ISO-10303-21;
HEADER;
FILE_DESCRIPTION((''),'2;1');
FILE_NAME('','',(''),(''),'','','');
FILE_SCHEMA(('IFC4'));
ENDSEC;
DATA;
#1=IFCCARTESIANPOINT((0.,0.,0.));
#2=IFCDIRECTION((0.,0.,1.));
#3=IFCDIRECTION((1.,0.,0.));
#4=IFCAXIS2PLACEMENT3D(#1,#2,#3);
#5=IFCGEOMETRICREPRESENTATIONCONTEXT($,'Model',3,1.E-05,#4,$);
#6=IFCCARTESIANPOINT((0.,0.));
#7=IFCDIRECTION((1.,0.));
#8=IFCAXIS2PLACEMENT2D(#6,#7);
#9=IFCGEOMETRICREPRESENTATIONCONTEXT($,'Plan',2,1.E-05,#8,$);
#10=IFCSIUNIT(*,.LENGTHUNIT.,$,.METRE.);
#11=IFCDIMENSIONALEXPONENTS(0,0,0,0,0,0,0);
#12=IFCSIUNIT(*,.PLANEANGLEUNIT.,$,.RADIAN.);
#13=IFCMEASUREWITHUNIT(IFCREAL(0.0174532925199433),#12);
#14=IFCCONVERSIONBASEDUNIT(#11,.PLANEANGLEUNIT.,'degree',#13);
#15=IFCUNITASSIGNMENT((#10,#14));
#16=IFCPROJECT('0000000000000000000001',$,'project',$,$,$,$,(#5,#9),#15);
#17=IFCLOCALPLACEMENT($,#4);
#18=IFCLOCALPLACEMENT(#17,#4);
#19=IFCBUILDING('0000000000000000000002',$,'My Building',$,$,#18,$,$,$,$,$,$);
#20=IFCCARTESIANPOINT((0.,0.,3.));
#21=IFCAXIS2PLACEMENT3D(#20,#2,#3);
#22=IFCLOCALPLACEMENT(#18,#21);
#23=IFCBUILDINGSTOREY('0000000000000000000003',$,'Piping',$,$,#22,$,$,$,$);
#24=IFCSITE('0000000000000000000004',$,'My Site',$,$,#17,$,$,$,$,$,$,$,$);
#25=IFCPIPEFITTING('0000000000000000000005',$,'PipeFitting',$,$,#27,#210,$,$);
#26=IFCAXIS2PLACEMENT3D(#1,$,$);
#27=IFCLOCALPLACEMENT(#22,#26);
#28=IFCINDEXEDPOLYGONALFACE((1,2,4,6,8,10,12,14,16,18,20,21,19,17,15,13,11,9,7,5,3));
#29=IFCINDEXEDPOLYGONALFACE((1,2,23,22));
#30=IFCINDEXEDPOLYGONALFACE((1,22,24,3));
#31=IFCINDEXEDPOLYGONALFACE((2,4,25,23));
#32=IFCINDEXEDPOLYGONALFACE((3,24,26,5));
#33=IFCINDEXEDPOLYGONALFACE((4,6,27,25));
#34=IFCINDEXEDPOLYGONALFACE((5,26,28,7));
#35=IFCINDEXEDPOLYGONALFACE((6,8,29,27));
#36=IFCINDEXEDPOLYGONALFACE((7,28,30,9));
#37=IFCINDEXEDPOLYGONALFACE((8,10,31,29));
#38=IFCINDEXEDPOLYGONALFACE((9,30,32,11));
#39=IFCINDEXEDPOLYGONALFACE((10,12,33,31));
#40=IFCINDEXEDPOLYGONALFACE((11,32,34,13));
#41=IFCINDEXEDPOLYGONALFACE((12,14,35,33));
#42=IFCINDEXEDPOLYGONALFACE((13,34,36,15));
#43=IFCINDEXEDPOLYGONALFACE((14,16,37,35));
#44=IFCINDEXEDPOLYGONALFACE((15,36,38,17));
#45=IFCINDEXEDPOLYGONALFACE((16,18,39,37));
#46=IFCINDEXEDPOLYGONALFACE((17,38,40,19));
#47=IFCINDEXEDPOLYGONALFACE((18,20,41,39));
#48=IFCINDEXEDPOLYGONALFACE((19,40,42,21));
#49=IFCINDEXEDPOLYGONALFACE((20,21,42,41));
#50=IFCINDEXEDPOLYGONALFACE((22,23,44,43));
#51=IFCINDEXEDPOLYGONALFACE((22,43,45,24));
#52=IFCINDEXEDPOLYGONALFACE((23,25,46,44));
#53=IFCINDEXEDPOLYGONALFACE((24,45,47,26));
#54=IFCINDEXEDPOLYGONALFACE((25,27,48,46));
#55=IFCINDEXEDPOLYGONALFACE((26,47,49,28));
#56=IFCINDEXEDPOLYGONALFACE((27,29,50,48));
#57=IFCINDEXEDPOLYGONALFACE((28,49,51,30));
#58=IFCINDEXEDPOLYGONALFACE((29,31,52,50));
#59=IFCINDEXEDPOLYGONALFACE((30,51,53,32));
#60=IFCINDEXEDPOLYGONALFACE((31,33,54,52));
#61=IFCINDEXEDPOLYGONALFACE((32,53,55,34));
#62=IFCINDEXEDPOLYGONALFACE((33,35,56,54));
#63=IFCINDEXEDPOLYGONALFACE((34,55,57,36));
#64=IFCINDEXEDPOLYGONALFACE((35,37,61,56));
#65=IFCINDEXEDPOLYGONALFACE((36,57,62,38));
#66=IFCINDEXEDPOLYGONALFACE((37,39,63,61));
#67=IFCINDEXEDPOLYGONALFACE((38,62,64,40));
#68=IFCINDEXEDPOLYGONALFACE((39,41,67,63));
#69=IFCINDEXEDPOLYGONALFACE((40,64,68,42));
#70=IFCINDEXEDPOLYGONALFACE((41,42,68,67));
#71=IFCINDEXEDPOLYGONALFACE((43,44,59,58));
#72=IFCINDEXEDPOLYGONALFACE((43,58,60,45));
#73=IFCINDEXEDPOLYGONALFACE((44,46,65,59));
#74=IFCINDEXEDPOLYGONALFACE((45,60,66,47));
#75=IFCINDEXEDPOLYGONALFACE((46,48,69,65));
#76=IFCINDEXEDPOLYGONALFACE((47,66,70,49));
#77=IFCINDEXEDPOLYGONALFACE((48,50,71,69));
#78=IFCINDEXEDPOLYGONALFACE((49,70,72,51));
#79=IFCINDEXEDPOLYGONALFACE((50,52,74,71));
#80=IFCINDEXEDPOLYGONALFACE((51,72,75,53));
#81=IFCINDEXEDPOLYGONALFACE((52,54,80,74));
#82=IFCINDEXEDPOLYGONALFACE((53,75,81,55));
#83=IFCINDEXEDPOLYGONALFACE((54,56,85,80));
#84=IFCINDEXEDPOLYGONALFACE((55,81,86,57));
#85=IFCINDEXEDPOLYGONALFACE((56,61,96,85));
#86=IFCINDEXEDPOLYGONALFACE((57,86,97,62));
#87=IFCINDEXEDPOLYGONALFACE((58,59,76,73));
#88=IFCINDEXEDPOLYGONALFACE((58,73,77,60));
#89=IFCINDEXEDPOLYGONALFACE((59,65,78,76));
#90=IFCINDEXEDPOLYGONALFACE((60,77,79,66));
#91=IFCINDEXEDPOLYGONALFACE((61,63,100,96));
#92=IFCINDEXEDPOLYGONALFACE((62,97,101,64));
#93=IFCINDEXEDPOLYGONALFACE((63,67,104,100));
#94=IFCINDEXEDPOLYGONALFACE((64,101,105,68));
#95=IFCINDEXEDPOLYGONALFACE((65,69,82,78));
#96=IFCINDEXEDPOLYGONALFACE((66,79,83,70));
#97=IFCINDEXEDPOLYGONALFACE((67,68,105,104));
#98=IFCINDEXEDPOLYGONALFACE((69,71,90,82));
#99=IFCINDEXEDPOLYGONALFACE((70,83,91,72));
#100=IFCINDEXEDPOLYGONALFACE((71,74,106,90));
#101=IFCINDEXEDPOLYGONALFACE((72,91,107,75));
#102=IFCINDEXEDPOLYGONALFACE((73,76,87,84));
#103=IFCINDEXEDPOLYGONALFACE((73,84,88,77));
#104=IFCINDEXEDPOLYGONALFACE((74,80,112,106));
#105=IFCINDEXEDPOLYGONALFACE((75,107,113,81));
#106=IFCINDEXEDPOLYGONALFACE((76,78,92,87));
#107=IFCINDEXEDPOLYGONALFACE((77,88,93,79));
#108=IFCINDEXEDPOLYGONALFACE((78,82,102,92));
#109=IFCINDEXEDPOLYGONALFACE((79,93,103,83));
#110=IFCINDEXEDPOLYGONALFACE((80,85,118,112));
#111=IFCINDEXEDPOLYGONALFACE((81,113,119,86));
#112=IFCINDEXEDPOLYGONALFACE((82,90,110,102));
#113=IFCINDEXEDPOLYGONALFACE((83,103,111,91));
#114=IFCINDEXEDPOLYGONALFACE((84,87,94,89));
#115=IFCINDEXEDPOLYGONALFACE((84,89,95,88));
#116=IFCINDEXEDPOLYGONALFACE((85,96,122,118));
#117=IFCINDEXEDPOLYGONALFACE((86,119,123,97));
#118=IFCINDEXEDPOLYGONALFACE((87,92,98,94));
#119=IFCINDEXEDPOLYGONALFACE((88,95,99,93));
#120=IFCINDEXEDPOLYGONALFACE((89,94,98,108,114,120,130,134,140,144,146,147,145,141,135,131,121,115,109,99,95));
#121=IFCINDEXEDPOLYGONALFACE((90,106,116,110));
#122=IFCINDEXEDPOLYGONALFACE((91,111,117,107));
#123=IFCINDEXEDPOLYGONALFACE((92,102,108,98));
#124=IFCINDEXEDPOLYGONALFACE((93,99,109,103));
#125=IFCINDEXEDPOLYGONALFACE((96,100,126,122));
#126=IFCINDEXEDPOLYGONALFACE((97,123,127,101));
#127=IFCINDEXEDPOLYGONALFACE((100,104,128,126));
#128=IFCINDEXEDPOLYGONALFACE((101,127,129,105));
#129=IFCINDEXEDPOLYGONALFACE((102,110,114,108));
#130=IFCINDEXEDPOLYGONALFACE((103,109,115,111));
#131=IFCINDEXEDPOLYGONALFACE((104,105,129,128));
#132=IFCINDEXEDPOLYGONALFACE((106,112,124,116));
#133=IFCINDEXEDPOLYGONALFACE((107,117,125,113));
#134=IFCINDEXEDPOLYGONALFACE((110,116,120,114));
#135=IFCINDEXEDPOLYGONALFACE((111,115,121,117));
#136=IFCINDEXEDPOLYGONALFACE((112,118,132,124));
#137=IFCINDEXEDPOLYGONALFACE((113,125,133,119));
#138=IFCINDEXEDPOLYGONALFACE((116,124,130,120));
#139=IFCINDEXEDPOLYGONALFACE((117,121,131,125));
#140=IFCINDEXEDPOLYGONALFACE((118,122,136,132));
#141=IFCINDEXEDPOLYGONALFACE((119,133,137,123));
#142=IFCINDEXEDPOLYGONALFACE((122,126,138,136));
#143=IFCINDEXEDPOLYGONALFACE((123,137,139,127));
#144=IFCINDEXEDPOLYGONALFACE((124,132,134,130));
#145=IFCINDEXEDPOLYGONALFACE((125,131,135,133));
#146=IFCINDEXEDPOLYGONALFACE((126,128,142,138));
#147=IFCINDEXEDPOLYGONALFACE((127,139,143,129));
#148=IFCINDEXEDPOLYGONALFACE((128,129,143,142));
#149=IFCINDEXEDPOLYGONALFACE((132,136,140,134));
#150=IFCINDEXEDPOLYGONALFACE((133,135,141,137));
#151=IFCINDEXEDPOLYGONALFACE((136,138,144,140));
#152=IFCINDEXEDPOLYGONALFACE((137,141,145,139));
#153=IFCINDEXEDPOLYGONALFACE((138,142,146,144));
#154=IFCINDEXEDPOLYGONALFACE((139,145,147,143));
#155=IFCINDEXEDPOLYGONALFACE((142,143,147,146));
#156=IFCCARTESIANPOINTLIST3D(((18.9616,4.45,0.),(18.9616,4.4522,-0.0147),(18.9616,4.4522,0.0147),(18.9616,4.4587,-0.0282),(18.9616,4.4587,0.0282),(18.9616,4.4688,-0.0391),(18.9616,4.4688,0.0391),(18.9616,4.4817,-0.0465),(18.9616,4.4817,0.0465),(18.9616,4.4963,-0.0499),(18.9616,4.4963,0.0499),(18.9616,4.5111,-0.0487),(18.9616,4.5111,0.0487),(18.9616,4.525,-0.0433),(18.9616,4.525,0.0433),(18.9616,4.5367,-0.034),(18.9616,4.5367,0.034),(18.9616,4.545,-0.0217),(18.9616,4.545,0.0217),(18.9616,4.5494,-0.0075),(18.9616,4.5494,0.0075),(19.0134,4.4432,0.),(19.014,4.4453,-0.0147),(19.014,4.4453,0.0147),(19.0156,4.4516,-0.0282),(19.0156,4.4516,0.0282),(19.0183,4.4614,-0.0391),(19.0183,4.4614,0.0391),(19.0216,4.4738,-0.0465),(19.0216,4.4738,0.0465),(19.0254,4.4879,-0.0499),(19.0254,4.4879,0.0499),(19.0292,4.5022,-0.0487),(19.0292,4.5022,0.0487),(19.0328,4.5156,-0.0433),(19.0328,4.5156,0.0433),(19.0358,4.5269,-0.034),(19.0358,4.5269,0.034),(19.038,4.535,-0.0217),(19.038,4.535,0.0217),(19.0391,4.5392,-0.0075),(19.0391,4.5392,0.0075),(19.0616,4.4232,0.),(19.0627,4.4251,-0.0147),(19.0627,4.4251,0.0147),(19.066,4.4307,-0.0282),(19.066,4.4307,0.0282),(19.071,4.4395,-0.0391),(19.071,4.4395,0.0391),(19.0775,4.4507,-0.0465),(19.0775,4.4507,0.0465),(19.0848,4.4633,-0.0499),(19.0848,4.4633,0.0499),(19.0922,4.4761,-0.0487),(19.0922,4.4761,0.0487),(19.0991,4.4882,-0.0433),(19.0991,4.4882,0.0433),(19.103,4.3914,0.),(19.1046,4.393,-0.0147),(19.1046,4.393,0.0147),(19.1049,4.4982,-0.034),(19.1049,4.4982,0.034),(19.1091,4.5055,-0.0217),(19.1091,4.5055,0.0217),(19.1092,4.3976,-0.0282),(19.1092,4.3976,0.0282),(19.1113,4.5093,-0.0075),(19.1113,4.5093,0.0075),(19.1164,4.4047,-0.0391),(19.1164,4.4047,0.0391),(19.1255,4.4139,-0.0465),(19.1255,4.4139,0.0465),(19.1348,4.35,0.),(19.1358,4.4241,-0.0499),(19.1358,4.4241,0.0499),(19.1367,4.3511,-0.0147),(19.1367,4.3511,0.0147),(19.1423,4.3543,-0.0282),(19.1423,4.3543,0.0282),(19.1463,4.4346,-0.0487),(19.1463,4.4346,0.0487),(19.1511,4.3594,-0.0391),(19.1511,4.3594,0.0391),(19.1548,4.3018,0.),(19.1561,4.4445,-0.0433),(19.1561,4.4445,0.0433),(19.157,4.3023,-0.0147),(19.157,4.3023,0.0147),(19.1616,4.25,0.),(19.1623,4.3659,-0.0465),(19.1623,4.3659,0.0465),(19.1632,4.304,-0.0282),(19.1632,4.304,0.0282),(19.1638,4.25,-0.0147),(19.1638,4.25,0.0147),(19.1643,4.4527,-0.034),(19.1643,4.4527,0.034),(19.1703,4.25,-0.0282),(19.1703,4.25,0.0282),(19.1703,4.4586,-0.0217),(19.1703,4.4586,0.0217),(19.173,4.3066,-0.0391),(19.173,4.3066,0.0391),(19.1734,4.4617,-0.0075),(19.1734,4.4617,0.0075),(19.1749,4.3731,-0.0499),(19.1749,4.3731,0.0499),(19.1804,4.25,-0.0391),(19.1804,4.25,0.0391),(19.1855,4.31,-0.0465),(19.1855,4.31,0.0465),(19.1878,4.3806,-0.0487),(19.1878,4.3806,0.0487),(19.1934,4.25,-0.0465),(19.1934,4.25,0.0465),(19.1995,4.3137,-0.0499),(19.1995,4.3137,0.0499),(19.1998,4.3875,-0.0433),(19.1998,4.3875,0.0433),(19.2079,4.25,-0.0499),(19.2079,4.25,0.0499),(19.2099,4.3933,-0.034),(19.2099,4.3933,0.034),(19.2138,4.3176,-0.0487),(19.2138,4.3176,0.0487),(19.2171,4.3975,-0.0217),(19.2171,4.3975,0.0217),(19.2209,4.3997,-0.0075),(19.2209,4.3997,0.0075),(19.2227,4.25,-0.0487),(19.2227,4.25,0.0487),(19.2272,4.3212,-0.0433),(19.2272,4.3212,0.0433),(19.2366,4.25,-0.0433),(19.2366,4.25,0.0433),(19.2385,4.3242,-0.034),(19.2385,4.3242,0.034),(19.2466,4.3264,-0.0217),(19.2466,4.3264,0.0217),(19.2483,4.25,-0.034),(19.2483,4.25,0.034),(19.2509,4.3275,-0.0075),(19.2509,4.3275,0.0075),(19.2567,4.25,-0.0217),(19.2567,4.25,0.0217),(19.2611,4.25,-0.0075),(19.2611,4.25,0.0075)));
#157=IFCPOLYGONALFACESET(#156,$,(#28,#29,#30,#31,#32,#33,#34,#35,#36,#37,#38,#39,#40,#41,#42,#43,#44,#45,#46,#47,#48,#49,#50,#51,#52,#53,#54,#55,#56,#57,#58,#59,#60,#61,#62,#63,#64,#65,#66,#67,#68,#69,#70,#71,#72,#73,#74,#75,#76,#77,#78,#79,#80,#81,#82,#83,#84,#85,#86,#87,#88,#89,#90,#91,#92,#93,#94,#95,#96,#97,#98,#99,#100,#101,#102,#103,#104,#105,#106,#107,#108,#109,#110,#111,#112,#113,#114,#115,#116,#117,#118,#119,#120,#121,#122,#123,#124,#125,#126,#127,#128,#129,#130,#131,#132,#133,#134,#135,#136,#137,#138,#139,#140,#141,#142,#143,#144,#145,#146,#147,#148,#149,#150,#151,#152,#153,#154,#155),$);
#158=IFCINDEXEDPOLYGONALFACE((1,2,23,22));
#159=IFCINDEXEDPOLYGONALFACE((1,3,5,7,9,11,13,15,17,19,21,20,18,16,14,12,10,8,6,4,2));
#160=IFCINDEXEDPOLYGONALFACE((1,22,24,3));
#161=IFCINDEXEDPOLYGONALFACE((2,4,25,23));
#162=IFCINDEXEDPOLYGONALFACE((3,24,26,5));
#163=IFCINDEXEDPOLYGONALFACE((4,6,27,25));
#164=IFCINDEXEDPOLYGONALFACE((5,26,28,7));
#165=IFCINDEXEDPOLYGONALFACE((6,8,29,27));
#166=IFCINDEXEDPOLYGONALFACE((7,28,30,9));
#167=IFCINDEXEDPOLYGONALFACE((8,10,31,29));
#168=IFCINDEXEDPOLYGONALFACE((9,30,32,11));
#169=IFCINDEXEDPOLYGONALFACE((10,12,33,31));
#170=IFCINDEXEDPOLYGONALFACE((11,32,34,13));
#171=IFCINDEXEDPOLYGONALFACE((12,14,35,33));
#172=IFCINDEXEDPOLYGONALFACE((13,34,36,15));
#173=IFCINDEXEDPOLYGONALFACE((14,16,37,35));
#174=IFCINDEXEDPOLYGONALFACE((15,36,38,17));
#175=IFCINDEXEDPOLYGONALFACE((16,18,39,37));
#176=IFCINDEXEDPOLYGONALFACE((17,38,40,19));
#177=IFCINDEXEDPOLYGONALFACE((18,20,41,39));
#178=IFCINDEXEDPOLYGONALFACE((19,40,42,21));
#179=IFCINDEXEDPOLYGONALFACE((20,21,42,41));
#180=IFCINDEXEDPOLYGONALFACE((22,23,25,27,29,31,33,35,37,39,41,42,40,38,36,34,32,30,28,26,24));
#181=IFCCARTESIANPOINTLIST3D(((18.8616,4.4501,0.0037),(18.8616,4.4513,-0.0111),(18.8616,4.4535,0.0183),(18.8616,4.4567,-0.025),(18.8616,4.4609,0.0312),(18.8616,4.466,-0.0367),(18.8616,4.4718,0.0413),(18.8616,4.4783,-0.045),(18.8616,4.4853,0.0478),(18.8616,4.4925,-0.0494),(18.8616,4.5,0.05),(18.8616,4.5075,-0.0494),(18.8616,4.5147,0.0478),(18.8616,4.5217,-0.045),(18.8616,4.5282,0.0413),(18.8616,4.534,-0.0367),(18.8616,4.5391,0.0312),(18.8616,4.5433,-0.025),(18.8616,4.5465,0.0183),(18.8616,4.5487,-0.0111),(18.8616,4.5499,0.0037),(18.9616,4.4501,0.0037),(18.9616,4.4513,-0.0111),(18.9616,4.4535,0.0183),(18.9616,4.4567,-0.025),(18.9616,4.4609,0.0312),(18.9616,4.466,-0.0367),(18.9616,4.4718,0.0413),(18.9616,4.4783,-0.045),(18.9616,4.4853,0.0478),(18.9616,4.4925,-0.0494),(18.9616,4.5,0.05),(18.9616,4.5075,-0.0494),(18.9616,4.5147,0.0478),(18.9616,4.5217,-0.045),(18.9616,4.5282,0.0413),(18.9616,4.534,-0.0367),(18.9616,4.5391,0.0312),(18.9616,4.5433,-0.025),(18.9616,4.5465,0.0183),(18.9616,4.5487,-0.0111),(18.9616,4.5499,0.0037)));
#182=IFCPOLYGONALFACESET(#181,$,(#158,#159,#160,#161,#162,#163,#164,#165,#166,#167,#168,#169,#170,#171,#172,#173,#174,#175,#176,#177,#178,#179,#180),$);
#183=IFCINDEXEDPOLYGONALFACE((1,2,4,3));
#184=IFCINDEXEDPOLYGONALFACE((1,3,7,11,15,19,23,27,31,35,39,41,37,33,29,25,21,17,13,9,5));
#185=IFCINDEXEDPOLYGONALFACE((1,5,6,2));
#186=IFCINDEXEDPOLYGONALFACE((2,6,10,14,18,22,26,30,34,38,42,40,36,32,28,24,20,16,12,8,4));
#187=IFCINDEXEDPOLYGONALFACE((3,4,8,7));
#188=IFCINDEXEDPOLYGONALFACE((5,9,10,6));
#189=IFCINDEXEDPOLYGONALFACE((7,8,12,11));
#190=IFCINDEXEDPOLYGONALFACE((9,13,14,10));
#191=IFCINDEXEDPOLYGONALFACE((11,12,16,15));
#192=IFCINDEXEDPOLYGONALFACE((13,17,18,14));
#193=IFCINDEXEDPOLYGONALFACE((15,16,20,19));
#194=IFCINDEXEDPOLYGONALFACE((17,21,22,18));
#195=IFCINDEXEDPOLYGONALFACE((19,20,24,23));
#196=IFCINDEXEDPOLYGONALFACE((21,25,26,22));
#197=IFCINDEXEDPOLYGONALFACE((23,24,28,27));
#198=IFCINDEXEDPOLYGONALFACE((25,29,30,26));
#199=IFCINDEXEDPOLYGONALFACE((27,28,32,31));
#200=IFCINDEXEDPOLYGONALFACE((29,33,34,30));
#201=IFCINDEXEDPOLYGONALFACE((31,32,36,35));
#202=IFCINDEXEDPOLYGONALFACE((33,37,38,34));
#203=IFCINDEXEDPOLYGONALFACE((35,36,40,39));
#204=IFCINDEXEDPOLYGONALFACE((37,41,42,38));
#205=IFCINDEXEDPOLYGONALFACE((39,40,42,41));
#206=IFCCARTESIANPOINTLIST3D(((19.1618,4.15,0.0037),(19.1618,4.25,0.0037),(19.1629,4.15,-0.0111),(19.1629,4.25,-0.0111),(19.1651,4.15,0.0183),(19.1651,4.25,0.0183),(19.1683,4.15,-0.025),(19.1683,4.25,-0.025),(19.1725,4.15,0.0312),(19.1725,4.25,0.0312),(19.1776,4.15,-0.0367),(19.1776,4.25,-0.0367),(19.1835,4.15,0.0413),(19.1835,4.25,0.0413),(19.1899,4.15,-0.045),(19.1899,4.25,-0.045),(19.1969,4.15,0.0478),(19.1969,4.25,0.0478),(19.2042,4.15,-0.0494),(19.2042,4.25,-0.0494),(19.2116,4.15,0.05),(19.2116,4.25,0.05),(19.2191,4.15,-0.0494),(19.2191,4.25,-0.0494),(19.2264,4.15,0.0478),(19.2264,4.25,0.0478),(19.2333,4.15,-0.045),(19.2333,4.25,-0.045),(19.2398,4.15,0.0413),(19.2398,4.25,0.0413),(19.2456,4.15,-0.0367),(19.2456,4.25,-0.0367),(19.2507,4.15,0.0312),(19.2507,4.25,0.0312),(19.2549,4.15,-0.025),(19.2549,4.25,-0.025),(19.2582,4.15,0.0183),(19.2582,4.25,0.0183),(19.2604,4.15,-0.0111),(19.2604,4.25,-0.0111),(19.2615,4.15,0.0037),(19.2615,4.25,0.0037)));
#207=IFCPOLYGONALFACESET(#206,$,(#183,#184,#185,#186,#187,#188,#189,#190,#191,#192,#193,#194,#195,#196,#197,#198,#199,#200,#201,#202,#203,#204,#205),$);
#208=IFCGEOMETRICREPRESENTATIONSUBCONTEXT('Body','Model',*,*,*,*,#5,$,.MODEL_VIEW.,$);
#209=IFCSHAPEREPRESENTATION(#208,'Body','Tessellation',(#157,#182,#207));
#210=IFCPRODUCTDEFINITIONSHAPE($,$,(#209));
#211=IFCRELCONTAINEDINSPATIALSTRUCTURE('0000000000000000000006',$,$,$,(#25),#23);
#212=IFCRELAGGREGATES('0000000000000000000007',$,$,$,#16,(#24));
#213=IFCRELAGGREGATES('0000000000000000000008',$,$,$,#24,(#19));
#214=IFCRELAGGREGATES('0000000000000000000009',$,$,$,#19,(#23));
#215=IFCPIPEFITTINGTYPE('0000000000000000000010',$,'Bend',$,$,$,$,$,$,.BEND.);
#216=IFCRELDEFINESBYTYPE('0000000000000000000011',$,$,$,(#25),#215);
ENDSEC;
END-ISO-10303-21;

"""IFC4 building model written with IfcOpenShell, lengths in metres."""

from ifc_helpers import new_model, entity, si_unit, converted_unit, frame, origin_with_axes, origin_2d_with_axis, place, context, subcontext, project, spatial, circle, extrude, source, transform, mapped, type_object, type_shapes, element, save


model = new_model("IFC4")

# Units and contexts
model_context = context("Model", 3, precision=1e-05, world=origin_with_axes())
plan_context = context("Plan", 2, precision=1e-05, world=origin_2d_with_axis())
body_context = subcontext(model_context, "Body", "Model", "MODEL_VIEW")
ifc_project = project(units=[si_unit("LENGTHUNIT", "METRE"), converted_unit("PLANEANGLEUNIT", "degree", entity("IfcReal", 0.0174532925199433), si_unit("PLANEANGLEUNIT", "RADIAN"), dimensions=[0, 0, 0, 0, 0, 0, 0])], contexts=[model_context, plan_context])

# Site, building, storey
site_placement = place(None, origin_with_axes())
site = spatial("IfcSite", under=ifc_project, at=site_placement, Name="My Site")
building_placement = place(site_placement, origin_with_axes())
building = spatial("IfcBuilding", under=site, at=building_placement, Name="My Building")
storey_placement = place(building_placement, frame((0.0, 0.0, 3.0), z_axis=(0.0, 0.0, 1.0), x_axis=(1.0, 0.0, 0.0)))
storey = spatial("IfcBuildingStorey", under=building, at=storey_placement, Name="Piping")

# Pipe fitting
pipe_fitting_type = type_object("IfcPipeFittingType", Name="Bend", PredefinedType="BEND")
shared_shape = source(origin_with_axes(), body_context, "Body", "SolidModel", [
    entity("IfcSweptDiskSolid", entity("IfcIndexedPolyCurve", entity("IfcCartesianPointList3D", [[0.0, 0.0, -0.1], [0.0, -0.0732, -0.2768], [0.0, -0.25, -0.35]]), [entity("IfcArcIndex", [1, 2, 3])]), 0.05),
    extrude(circle(Radius=0.05), origin_with_axes(), (0.0, 0.0, -1.0), 0.1),
    extrude(circle(Radius=0.05), frame((0.0, -0.25, -0.35), z_axis=(0.0, -1.0, 0.0), x_axis=(1.0, 0.0, 0.0)), (0.0, 0.0, 1.0), 0.1),
])
type_shapes(pipe_fitting_type, [shared_shape])
for number, where, z_axis, x_axis, name in (
    (1, (18.8616, 4.5, 0.0), (-1.0, 0.0, 0.0), (0.0, 0.0, 1.0), "PipeFitting"),
):
    element("IfcPipeFitting", number, at=place(storey_placement, frame(where, z_axis=z_axis, x_axis=x_axis)), inside=storey, type_object=pipe_fitting_type, Name=name, context=body_context, shape_type="MappedRepresentation", body=[
        mapped(shared_shape, transform((0.0, 0.0, 0.0), x_axis=(1.0, 0.0, 0.0), y_axis=(0.0, 1.0, 0.0), z_axis=(0.0, 0.0, 1.0), scale=1.0)),
    ])

save(model, "model.ifc")
